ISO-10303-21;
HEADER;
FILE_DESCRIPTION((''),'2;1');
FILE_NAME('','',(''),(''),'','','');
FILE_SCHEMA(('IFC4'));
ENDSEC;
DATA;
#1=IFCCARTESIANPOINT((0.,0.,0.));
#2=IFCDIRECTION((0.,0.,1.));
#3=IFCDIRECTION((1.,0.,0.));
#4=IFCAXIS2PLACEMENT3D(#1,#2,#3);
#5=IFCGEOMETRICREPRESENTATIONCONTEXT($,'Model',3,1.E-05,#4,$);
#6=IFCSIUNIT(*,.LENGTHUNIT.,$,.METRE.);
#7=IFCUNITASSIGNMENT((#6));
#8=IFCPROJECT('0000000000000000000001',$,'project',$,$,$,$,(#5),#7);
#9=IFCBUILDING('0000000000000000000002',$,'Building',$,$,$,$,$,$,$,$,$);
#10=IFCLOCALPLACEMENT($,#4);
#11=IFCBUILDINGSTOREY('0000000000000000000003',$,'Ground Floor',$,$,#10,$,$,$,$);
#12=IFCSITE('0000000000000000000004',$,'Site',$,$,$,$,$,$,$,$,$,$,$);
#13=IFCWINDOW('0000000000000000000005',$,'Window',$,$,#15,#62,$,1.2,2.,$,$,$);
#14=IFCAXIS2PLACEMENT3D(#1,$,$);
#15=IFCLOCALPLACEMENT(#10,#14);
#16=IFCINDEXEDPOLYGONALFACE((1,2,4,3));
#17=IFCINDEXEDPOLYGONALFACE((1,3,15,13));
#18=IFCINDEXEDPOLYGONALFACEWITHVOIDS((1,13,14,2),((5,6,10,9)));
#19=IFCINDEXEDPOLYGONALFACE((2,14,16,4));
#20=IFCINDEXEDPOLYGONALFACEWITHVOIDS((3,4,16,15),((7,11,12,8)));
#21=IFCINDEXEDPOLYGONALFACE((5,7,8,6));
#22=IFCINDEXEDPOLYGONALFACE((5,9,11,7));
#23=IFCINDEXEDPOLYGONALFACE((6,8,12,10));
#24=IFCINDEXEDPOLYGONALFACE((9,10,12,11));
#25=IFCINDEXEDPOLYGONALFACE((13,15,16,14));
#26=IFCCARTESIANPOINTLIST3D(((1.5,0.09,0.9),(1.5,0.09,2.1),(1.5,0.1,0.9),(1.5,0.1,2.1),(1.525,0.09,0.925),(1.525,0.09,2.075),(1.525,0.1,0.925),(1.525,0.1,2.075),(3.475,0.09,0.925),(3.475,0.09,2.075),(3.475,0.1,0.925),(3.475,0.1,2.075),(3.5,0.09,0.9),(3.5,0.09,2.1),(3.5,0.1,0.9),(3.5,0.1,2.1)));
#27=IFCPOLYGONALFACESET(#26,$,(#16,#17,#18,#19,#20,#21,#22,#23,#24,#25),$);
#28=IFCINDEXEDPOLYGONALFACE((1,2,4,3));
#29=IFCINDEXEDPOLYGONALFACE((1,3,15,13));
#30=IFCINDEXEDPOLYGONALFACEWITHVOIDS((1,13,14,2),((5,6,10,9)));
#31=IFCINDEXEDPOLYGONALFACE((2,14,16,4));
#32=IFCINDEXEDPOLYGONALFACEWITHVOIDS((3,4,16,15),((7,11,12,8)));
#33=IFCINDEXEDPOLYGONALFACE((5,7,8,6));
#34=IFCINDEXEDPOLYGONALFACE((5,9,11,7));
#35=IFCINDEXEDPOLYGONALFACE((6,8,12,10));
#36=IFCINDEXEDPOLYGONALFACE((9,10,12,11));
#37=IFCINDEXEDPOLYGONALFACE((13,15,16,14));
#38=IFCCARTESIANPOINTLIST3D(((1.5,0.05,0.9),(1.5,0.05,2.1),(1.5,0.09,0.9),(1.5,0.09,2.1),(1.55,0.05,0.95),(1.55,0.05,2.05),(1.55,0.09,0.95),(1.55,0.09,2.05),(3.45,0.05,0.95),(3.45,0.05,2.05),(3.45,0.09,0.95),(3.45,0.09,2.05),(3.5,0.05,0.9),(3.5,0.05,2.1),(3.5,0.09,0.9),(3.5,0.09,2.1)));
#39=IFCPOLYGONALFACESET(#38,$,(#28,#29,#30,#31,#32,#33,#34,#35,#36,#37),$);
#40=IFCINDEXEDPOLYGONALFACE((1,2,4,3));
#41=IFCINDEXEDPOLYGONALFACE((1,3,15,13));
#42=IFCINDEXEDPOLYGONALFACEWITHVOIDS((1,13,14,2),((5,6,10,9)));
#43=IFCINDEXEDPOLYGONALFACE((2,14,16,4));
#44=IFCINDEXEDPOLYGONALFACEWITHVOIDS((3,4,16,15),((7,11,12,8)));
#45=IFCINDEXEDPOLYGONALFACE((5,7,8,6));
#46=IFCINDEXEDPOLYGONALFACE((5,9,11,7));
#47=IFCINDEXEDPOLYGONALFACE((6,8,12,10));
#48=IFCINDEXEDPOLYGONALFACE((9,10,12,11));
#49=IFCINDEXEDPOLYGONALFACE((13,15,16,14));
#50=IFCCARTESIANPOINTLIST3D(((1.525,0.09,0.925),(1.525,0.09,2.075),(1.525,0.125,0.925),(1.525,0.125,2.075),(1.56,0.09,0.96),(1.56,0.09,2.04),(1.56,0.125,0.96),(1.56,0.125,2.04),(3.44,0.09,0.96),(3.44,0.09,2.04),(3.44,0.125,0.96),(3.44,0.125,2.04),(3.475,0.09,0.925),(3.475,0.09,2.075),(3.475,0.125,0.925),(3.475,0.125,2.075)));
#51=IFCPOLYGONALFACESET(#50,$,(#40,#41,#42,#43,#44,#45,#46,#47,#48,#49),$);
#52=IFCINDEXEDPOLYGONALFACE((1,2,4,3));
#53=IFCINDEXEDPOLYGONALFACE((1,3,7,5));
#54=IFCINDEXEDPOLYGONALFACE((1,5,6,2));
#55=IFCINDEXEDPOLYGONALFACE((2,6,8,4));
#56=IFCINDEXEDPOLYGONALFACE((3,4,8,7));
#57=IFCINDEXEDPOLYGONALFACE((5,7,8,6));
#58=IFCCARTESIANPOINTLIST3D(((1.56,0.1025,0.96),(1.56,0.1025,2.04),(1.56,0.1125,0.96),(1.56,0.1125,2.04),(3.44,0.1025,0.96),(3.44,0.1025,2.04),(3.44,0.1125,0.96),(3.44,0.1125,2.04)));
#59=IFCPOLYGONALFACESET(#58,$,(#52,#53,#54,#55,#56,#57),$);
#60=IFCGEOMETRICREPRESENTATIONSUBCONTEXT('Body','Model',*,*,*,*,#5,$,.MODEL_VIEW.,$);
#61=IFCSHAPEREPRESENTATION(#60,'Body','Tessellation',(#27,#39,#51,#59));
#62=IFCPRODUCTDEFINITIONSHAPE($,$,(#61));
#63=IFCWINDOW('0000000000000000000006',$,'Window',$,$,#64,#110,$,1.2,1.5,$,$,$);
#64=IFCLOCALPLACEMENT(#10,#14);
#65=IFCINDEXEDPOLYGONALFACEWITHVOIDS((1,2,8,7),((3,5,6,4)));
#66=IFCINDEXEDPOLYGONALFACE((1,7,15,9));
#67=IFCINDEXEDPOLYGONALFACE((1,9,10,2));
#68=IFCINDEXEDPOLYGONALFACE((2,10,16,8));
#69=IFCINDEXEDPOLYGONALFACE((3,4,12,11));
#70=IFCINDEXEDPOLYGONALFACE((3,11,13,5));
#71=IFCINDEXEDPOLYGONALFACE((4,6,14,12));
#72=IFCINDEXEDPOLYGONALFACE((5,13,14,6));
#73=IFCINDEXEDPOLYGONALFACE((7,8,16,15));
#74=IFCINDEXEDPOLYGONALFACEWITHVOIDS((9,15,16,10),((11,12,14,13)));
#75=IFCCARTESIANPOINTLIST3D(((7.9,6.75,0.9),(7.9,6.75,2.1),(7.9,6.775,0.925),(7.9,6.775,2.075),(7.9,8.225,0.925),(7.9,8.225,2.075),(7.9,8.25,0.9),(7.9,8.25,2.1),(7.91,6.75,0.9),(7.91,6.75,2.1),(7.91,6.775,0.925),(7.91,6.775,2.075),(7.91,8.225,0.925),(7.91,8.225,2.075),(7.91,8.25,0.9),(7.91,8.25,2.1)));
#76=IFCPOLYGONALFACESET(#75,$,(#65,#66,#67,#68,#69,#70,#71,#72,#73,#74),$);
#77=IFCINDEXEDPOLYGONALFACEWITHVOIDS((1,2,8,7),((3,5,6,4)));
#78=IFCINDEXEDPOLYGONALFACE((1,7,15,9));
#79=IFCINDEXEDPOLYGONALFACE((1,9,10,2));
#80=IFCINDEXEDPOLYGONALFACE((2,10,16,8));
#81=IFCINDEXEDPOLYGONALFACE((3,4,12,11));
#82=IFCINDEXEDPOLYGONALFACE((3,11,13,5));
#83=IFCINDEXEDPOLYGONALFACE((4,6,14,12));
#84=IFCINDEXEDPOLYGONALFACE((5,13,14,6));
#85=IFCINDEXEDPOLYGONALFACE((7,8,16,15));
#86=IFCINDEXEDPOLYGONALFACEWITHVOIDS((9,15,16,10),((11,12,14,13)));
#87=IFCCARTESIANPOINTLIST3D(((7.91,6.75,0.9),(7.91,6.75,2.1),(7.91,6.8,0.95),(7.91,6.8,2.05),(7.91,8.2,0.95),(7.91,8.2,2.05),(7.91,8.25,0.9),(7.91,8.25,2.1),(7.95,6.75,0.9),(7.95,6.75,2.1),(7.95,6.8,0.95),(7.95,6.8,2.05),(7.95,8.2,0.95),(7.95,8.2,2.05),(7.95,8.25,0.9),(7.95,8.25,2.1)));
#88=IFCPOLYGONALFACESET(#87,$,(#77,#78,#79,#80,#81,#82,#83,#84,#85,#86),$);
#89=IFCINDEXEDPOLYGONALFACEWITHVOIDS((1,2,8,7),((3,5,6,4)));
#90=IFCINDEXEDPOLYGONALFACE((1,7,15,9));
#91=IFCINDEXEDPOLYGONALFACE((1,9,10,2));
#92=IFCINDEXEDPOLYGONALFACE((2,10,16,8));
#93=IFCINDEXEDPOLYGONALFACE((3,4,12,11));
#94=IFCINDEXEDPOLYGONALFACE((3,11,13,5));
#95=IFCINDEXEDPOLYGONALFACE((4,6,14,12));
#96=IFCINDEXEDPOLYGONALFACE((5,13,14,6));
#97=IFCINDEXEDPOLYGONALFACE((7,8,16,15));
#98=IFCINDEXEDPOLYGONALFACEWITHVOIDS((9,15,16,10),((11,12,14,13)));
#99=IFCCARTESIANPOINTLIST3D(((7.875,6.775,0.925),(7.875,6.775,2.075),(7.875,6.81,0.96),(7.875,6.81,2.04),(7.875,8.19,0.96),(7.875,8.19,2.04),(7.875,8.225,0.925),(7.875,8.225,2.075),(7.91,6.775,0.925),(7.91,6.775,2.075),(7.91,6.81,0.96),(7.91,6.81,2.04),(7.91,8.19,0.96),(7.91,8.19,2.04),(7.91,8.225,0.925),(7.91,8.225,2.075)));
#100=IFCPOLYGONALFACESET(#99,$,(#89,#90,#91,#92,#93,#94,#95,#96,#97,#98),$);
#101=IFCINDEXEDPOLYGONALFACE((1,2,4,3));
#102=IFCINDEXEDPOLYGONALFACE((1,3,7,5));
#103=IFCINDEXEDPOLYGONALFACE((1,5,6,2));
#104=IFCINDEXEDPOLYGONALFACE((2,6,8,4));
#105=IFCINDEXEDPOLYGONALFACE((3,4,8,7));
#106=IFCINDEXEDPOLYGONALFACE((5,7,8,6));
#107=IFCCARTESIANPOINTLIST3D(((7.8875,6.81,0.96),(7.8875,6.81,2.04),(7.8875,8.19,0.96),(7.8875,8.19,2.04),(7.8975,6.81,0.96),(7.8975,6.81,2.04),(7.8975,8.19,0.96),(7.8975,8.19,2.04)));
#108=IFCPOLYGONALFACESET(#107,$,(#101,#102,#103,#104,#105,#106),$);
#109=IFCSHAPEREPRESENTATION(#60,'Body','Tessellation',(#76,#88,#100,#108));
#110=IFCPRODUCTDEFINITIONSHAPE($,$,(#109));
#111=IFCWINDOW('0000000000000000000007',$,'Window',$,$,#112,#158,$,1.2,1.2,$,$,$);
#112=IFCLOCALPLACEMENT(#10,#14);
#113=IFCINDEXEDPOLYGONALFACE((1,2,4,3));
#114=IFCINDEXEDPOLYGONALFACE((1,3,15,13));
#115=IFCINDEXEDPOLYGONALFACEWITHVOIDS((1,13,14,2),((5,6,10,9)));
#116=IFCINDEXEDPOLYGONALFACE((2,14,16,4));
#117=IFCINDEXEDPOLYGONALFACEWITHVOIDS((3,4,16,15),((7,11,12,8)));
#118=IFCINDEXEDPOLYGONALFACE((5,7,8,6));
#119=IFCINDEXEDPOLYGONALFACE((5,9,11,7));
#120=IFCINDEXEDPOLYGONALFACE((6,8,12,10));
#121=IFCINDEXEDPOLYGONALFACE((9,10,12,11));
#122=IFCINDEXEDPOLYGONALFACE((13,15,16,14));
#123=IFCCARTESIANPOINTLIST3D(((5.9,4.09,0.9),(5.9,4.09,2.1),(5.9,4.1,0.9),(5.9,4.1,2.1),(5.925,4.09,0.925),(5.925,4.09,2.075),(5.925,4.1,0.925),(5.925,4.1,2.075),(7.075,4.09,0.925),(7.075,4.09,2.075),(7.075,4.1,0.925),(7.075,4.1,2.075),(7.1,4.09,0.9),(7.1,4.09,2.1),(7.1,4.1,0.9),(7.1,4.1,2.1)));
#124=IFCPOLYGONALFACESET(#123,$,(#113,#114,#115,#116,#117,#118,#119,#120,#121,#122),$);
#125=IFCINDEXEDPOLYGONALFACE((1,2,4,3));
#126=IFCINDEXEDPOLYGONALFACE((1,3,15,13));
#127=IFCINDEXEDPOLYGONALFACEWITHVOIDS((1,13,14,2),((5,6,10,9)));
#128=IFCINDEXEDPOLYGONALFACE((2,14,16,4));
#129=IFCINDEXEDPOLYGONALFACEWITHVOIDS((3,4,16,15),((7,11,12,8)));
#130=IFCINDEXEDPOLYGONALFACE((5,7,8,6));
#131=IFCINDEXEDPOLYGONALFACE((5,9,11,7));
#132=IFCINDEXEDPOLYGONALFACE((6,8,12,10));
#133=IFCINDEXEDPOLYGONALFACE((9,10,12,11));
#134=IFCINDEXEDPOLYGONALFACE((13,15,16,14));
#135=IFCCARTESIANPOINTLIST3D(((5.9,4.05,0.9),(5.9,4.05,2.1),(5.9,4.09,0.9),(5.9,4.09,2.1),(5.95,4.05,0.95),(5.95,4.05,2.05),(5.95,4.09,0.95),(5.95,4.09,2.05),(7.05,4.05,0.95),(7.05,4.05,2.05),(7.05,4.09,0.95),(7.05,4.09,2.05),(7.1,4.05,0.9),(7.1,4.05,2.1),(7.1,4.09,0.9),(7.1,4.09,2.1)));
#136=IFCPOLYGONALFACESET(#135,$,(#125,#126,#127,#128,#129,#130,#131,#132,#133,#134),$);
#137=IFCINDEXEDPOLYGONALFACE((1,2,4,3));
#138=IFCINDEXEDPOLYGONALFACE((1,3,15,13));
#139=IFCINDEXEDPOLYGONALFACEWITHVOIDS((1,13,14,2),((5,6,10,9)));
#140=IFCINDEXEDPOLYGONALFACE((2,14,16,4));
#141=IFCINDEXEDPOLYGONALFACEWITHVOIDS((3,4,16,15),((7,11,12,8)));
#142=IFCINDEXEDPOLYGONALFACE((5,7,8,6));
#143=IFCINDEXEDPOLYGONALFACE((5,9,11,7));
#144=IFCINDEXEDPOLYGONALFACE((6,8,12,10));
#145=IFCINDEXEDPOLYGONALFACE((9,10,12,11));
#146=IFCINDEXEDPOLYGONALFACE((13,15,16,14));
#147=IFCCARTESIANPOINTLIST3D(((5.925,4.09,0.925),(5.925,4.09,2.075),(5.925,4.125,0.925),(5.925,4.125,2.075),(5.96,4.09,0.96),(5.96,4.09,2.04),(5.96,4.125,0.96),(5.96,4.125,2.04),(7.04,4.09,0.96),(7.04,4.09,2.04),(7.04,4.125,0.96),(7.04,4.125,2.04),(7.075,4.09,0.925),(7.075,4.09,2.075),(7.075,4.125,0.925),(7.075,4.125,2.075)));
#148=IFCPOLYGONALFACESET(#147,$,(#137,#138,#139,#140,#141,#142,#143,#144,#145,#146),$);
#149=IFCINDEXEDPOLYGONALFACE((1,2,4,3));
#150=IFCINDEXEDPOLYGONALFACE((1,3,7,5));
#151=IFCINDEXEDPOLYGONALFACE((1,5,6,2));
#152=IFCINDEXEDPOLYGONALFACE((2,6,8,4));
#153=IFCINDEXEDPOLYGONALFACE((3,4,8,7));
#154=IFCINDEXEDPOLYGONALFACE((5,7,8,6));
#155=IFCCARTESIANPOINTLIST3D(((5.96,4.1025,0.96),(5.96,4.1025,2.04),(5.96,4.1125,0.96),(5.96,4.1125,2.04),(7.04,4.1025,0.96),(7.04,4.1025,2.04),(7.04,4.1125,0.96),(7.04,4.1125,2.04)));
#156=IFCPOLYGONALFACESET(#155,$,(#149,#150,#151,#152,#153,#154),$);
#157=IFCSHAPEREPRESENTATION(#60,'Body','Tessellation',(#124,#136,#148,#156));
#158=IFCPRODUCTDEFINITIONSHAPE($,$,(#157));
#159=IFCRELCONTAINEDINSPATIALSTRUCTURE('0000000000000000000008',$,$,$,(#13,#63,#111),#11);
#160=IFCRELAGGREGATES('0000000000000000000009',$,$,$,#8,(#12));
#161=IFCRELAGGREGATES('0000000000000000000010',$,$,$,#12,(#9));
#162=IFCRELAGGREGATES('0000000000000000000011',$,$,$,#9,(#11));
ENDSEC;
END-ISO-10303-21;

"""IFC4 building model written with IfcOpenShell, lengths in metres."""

from ifc_helpers import new_model, si_unit, frame, origin_with_axes, place, context, subcontext, project, spatial, line, indexed_curve, outline, extrude, element, save


model = new_model("IFC4")

# Units and contexts
model_context = context("Model", 3, precision=1e-05, world=origin_with_axes())
body_context = subcontext(model_context, "Body", "Model", "MODEL_VIEW")
ifc_project = project(units=[si_unit("LENGTHUNIT", "METRE")], contexts=[model_context])

# Site, building, storey
site = spatial("IfcSite", under=ifc_project, Name="Site")
building = spatial("IfcBuilding", under=site, Name="Building")
storey_placement = place(None, origin_with_axes())
storey = spatial("IfcBuildingStorey", under=building, at=storey_placement, Name="Ground Floor")

# Windows
window_1_placement = place(storey_placement, frame((1.5, 0.0, 0.9), z_axis=(0.0, 0.0, 1.0), x_axis=(1.0, 0.0, 0.0)))
element("IfcWindow", 1, at=window_1_placement, inside=storey, Name="Window", OverallHeight=1.2, OverallWidth=2.0, context=body_context, shape_type="SweptSolid", body=[
    extrude(outline(indexed_curve([(0.0, 0.0), (2.0, 0.0), (2.0, 1.2), (0.0, 1.2)], segments=[line(1, 2, 3, 4, 1)]), holes=[indexed_curve([(0.025, 0.025), (1.975, 0.025), (1.975, 1.175), (0.025, 1.175)], segments=[line(1, 2, 3, 4, 1)])]), frame((0.0, 0.09, 0.0), z_axis=(0.0, -1.0, 0.0), x_axis=(1.0, 0.0, 0.0)), (0.0, 0.0, -1.0), 0.01),
    extrude(outline(indexed_curve([(0.0, 0.0), (2.0, 0.0), (2.0, 1.2), (0.0, 1.2)], segments=[line(1, 2, 3, 4, 1)]), holes=[indexed_curve([(0.05, 0.05), (1.95, 0.05), (1.95, 1.15), (0.05, 1.15)], segments=[line(1, 2, 3, 4, 1)])]), frame((0.0, 0.05, 0.0), z_axis=(0.0, -1.0, 0.0), x_axis=(1.0, 0.0, 0.0)), (0.0, 0.0, -1.0), 0.04),
    extrude(outline(indexed_curve([(0.0, 0.0), (1.95, 0.0), (1.95, 1.15), (0.0, 1.15)], segments=[line(1, 2, 3, 4, 1)]), holes=[indexed_curve([(0.035, 0.035), (1.915, 0.035), (1.915, 1.115), (0.035, 1.115)], segments=[line(1, 2, 3, 4, 1)])]), frame((0.025, 0.09, 0.025), z_axis=(0.0, -1.0, 0.0), x_axis=(1.0, 0.0, 0.0)), (0.0, 0.0, -1.0), 0.035),
    extrude(outline(indexed_curve([(0.035, 0.035), (1.915, 0.035), (1.915, 1.115), (0.035, 1.115)], segments=[line(1, 2, 3, 4, 1)])), frame((0.025, 0.1025, 0.025), z_axis=(0.0, -1.0, 0.0), x_axis=(1.0, 0.0, 0.0)), (0.0, 0.0, -1.0), 0.01),
])
window_2_placement = place(storey_placement, frame((8.0, 6.75, 0.9), z_axis=(0.0, 0.0, 1.0), x_axis=(0.0, 1.0, 0.0)))
element("IfcWindow", 2, at=window_2_placement, inside=storey, Name="Window", OverallHeight=1.2, OverallWidth=1.5, context=body_context, shape_type="SweptSolid", body=[
    extrude(outline(indexed_curve([(0.0, 0.0), (1.5, 0.0), (1.5, 1.2), (0.0, 1.2)], segments=[line(1, 2, 3, 4, 1)]), holes=[indexed_curve([(0.025, 0.025), (1.475, 0.025), (1.475, 1.175), (0.025, 1.175)], segments=[line(1, 2, 3, 4, 1)])]), frame((0.0, 0.09, 0.0), z_axis=(0.0, -1.0, 0.0), x_axis=(1.0, 0.0, 0.0)), (0.0, 0.0, -1.0), 0.01),
    extrude(outline(indexed_curve([(0.0, 0.0), (1.5, 0.0), (1.5, 1.2), (0.0, 1.2)], segments=[line(1, 2, 3, 4, 1)]), holes=[indexed_curve([(0.05, 0.05), (1.45, 0.05), (1.45, 1.15), (0.05, 1.15)], segments=[line(1, 2, 3, 4, 1)])]), frame((0.0, 0.05, 0.0), z_axis=(0.0, -1.0, 0.0), x_axis=(1.0, 0.0, 0.0)), (0.0, 0.0, -1.0), 0.04),
    extrude(outline(indexed_curve([(0.0, 0.0), (1.45, 0.0), (1.45, 1.15), (0.0, 1.15)], segments=[line(1, 2, 3, 4, 1)]), holes=[indexed_curve([(0.035, 0.035), (1.415, 0.035), (1.415, 1.115), (0.035, 1.115)], segments=[line(1, 2, 3, 4, 1)])]), frame((0.025, 0.09, 0.025), z_axis=(0.0, -1.0, 0.0), x_axis=(1.0, 0.0, 0.0)), (0.0, 0.0, -1.0), 0.035),
    extrude(outline(indexed_curve([(0.035, 0.035), (1.415, 0.035), (1.415, 1.115), (0.035, 1.115)], segments=[line(1, 2, 3, 4, 1)])), frame((0.025, 0.1025, 0.025), z_axis=(0.0, -1.0, 0.0), x_axis=(1.0, 0.0, 0.0)), (0.0, 0.0, -1.0), 0.01),
])
window_3_placement = place(storey_placement, frame((5.9, 4.0, 0.9), z_axis=(0.0, 0.0, 1.0), x_axis=(1.0, 0.0, 0.0)))
element("IfcWindow", 3, at=window_3_placement, inside=storey, Name="Window", OverallHeight=1.2, OverallWidth=1.2, context=body_context, shape_type="SweptSolid", body=[
    extrude(outline(indexed_curve([(0.0, 0.0), (1.2, 0.0), (1.2, 1.2), (0.0, 1.2)], segments=[line(1, 2, 3, 4, 1)]), holes=[indexed_curve([(0.025, 0.025), (1.175, 0.025), (1.175, 1.175), (0.025, 1.175)], segments=[line(1, 2, 3, 4, 1)])]), frame((0.0, 0.09, 0.0), z_axis=(0.0, -1.0, 0.0), x_axis=(1.0, 0.0, 0.0)), (0.0, 0.0, -1.0), 0.01),
    extrude(outline(indexed_curve([(0.0, 0.0), (1.2, 0.0), (1.2, 1.2), (0.0, 1.2)], segments=[line(1, 2, 3, 4, 1)]), holes=[indexed_curve([(0.05, 0.05), (1.15, 0.05), (1.15, 1.15), (0.05, 1.15)], segments=[line(1, 2, 3, 4, 1)])]), frame((0.0, 0.05, 0.0), z_axis=(0.0, -1.0, 0.0), x_axis=(1.0, 0.0, 0.0)), (0.0, 0.0, -1.0), 0.04),
    extrude(outline(indexed_curve([(0.0, 0.0), (1.15, 0.0), (1.15, 1.15), (0.0, 1.15)], segments=[line(1, 2, 3, 4, 1)]), holes=[indexed_curve([(0.035, 0.035), (1.115, 0.035), (1.115, 1.115), (0.035, 1.115)], segments=[line(1, 2, 3, 4, 1)])]), frame((0.025, 0.09, 0.025), z_axis=(0.0, -1.0, 0.0), x_axis=(1.0, 0.0, 0.0)), (0.0, 0.0, -1.0), 0.035),
    extrude(outline(indexed_curve([(0.035, 0.035), (1.115, 0.035), (1.115, 1.115), (0.035, 1.115)], segments=[line(1, 2, 3, 4, 1)])), frame((0.025, 0.1025, 0.025), z_axis=(0.0, -1.0, 0.0), x_axis=(1.0, 0.0, 0.0)), (0.0, 0.0, -1.0), 0.01),
])

save(model, "model.ifc")
